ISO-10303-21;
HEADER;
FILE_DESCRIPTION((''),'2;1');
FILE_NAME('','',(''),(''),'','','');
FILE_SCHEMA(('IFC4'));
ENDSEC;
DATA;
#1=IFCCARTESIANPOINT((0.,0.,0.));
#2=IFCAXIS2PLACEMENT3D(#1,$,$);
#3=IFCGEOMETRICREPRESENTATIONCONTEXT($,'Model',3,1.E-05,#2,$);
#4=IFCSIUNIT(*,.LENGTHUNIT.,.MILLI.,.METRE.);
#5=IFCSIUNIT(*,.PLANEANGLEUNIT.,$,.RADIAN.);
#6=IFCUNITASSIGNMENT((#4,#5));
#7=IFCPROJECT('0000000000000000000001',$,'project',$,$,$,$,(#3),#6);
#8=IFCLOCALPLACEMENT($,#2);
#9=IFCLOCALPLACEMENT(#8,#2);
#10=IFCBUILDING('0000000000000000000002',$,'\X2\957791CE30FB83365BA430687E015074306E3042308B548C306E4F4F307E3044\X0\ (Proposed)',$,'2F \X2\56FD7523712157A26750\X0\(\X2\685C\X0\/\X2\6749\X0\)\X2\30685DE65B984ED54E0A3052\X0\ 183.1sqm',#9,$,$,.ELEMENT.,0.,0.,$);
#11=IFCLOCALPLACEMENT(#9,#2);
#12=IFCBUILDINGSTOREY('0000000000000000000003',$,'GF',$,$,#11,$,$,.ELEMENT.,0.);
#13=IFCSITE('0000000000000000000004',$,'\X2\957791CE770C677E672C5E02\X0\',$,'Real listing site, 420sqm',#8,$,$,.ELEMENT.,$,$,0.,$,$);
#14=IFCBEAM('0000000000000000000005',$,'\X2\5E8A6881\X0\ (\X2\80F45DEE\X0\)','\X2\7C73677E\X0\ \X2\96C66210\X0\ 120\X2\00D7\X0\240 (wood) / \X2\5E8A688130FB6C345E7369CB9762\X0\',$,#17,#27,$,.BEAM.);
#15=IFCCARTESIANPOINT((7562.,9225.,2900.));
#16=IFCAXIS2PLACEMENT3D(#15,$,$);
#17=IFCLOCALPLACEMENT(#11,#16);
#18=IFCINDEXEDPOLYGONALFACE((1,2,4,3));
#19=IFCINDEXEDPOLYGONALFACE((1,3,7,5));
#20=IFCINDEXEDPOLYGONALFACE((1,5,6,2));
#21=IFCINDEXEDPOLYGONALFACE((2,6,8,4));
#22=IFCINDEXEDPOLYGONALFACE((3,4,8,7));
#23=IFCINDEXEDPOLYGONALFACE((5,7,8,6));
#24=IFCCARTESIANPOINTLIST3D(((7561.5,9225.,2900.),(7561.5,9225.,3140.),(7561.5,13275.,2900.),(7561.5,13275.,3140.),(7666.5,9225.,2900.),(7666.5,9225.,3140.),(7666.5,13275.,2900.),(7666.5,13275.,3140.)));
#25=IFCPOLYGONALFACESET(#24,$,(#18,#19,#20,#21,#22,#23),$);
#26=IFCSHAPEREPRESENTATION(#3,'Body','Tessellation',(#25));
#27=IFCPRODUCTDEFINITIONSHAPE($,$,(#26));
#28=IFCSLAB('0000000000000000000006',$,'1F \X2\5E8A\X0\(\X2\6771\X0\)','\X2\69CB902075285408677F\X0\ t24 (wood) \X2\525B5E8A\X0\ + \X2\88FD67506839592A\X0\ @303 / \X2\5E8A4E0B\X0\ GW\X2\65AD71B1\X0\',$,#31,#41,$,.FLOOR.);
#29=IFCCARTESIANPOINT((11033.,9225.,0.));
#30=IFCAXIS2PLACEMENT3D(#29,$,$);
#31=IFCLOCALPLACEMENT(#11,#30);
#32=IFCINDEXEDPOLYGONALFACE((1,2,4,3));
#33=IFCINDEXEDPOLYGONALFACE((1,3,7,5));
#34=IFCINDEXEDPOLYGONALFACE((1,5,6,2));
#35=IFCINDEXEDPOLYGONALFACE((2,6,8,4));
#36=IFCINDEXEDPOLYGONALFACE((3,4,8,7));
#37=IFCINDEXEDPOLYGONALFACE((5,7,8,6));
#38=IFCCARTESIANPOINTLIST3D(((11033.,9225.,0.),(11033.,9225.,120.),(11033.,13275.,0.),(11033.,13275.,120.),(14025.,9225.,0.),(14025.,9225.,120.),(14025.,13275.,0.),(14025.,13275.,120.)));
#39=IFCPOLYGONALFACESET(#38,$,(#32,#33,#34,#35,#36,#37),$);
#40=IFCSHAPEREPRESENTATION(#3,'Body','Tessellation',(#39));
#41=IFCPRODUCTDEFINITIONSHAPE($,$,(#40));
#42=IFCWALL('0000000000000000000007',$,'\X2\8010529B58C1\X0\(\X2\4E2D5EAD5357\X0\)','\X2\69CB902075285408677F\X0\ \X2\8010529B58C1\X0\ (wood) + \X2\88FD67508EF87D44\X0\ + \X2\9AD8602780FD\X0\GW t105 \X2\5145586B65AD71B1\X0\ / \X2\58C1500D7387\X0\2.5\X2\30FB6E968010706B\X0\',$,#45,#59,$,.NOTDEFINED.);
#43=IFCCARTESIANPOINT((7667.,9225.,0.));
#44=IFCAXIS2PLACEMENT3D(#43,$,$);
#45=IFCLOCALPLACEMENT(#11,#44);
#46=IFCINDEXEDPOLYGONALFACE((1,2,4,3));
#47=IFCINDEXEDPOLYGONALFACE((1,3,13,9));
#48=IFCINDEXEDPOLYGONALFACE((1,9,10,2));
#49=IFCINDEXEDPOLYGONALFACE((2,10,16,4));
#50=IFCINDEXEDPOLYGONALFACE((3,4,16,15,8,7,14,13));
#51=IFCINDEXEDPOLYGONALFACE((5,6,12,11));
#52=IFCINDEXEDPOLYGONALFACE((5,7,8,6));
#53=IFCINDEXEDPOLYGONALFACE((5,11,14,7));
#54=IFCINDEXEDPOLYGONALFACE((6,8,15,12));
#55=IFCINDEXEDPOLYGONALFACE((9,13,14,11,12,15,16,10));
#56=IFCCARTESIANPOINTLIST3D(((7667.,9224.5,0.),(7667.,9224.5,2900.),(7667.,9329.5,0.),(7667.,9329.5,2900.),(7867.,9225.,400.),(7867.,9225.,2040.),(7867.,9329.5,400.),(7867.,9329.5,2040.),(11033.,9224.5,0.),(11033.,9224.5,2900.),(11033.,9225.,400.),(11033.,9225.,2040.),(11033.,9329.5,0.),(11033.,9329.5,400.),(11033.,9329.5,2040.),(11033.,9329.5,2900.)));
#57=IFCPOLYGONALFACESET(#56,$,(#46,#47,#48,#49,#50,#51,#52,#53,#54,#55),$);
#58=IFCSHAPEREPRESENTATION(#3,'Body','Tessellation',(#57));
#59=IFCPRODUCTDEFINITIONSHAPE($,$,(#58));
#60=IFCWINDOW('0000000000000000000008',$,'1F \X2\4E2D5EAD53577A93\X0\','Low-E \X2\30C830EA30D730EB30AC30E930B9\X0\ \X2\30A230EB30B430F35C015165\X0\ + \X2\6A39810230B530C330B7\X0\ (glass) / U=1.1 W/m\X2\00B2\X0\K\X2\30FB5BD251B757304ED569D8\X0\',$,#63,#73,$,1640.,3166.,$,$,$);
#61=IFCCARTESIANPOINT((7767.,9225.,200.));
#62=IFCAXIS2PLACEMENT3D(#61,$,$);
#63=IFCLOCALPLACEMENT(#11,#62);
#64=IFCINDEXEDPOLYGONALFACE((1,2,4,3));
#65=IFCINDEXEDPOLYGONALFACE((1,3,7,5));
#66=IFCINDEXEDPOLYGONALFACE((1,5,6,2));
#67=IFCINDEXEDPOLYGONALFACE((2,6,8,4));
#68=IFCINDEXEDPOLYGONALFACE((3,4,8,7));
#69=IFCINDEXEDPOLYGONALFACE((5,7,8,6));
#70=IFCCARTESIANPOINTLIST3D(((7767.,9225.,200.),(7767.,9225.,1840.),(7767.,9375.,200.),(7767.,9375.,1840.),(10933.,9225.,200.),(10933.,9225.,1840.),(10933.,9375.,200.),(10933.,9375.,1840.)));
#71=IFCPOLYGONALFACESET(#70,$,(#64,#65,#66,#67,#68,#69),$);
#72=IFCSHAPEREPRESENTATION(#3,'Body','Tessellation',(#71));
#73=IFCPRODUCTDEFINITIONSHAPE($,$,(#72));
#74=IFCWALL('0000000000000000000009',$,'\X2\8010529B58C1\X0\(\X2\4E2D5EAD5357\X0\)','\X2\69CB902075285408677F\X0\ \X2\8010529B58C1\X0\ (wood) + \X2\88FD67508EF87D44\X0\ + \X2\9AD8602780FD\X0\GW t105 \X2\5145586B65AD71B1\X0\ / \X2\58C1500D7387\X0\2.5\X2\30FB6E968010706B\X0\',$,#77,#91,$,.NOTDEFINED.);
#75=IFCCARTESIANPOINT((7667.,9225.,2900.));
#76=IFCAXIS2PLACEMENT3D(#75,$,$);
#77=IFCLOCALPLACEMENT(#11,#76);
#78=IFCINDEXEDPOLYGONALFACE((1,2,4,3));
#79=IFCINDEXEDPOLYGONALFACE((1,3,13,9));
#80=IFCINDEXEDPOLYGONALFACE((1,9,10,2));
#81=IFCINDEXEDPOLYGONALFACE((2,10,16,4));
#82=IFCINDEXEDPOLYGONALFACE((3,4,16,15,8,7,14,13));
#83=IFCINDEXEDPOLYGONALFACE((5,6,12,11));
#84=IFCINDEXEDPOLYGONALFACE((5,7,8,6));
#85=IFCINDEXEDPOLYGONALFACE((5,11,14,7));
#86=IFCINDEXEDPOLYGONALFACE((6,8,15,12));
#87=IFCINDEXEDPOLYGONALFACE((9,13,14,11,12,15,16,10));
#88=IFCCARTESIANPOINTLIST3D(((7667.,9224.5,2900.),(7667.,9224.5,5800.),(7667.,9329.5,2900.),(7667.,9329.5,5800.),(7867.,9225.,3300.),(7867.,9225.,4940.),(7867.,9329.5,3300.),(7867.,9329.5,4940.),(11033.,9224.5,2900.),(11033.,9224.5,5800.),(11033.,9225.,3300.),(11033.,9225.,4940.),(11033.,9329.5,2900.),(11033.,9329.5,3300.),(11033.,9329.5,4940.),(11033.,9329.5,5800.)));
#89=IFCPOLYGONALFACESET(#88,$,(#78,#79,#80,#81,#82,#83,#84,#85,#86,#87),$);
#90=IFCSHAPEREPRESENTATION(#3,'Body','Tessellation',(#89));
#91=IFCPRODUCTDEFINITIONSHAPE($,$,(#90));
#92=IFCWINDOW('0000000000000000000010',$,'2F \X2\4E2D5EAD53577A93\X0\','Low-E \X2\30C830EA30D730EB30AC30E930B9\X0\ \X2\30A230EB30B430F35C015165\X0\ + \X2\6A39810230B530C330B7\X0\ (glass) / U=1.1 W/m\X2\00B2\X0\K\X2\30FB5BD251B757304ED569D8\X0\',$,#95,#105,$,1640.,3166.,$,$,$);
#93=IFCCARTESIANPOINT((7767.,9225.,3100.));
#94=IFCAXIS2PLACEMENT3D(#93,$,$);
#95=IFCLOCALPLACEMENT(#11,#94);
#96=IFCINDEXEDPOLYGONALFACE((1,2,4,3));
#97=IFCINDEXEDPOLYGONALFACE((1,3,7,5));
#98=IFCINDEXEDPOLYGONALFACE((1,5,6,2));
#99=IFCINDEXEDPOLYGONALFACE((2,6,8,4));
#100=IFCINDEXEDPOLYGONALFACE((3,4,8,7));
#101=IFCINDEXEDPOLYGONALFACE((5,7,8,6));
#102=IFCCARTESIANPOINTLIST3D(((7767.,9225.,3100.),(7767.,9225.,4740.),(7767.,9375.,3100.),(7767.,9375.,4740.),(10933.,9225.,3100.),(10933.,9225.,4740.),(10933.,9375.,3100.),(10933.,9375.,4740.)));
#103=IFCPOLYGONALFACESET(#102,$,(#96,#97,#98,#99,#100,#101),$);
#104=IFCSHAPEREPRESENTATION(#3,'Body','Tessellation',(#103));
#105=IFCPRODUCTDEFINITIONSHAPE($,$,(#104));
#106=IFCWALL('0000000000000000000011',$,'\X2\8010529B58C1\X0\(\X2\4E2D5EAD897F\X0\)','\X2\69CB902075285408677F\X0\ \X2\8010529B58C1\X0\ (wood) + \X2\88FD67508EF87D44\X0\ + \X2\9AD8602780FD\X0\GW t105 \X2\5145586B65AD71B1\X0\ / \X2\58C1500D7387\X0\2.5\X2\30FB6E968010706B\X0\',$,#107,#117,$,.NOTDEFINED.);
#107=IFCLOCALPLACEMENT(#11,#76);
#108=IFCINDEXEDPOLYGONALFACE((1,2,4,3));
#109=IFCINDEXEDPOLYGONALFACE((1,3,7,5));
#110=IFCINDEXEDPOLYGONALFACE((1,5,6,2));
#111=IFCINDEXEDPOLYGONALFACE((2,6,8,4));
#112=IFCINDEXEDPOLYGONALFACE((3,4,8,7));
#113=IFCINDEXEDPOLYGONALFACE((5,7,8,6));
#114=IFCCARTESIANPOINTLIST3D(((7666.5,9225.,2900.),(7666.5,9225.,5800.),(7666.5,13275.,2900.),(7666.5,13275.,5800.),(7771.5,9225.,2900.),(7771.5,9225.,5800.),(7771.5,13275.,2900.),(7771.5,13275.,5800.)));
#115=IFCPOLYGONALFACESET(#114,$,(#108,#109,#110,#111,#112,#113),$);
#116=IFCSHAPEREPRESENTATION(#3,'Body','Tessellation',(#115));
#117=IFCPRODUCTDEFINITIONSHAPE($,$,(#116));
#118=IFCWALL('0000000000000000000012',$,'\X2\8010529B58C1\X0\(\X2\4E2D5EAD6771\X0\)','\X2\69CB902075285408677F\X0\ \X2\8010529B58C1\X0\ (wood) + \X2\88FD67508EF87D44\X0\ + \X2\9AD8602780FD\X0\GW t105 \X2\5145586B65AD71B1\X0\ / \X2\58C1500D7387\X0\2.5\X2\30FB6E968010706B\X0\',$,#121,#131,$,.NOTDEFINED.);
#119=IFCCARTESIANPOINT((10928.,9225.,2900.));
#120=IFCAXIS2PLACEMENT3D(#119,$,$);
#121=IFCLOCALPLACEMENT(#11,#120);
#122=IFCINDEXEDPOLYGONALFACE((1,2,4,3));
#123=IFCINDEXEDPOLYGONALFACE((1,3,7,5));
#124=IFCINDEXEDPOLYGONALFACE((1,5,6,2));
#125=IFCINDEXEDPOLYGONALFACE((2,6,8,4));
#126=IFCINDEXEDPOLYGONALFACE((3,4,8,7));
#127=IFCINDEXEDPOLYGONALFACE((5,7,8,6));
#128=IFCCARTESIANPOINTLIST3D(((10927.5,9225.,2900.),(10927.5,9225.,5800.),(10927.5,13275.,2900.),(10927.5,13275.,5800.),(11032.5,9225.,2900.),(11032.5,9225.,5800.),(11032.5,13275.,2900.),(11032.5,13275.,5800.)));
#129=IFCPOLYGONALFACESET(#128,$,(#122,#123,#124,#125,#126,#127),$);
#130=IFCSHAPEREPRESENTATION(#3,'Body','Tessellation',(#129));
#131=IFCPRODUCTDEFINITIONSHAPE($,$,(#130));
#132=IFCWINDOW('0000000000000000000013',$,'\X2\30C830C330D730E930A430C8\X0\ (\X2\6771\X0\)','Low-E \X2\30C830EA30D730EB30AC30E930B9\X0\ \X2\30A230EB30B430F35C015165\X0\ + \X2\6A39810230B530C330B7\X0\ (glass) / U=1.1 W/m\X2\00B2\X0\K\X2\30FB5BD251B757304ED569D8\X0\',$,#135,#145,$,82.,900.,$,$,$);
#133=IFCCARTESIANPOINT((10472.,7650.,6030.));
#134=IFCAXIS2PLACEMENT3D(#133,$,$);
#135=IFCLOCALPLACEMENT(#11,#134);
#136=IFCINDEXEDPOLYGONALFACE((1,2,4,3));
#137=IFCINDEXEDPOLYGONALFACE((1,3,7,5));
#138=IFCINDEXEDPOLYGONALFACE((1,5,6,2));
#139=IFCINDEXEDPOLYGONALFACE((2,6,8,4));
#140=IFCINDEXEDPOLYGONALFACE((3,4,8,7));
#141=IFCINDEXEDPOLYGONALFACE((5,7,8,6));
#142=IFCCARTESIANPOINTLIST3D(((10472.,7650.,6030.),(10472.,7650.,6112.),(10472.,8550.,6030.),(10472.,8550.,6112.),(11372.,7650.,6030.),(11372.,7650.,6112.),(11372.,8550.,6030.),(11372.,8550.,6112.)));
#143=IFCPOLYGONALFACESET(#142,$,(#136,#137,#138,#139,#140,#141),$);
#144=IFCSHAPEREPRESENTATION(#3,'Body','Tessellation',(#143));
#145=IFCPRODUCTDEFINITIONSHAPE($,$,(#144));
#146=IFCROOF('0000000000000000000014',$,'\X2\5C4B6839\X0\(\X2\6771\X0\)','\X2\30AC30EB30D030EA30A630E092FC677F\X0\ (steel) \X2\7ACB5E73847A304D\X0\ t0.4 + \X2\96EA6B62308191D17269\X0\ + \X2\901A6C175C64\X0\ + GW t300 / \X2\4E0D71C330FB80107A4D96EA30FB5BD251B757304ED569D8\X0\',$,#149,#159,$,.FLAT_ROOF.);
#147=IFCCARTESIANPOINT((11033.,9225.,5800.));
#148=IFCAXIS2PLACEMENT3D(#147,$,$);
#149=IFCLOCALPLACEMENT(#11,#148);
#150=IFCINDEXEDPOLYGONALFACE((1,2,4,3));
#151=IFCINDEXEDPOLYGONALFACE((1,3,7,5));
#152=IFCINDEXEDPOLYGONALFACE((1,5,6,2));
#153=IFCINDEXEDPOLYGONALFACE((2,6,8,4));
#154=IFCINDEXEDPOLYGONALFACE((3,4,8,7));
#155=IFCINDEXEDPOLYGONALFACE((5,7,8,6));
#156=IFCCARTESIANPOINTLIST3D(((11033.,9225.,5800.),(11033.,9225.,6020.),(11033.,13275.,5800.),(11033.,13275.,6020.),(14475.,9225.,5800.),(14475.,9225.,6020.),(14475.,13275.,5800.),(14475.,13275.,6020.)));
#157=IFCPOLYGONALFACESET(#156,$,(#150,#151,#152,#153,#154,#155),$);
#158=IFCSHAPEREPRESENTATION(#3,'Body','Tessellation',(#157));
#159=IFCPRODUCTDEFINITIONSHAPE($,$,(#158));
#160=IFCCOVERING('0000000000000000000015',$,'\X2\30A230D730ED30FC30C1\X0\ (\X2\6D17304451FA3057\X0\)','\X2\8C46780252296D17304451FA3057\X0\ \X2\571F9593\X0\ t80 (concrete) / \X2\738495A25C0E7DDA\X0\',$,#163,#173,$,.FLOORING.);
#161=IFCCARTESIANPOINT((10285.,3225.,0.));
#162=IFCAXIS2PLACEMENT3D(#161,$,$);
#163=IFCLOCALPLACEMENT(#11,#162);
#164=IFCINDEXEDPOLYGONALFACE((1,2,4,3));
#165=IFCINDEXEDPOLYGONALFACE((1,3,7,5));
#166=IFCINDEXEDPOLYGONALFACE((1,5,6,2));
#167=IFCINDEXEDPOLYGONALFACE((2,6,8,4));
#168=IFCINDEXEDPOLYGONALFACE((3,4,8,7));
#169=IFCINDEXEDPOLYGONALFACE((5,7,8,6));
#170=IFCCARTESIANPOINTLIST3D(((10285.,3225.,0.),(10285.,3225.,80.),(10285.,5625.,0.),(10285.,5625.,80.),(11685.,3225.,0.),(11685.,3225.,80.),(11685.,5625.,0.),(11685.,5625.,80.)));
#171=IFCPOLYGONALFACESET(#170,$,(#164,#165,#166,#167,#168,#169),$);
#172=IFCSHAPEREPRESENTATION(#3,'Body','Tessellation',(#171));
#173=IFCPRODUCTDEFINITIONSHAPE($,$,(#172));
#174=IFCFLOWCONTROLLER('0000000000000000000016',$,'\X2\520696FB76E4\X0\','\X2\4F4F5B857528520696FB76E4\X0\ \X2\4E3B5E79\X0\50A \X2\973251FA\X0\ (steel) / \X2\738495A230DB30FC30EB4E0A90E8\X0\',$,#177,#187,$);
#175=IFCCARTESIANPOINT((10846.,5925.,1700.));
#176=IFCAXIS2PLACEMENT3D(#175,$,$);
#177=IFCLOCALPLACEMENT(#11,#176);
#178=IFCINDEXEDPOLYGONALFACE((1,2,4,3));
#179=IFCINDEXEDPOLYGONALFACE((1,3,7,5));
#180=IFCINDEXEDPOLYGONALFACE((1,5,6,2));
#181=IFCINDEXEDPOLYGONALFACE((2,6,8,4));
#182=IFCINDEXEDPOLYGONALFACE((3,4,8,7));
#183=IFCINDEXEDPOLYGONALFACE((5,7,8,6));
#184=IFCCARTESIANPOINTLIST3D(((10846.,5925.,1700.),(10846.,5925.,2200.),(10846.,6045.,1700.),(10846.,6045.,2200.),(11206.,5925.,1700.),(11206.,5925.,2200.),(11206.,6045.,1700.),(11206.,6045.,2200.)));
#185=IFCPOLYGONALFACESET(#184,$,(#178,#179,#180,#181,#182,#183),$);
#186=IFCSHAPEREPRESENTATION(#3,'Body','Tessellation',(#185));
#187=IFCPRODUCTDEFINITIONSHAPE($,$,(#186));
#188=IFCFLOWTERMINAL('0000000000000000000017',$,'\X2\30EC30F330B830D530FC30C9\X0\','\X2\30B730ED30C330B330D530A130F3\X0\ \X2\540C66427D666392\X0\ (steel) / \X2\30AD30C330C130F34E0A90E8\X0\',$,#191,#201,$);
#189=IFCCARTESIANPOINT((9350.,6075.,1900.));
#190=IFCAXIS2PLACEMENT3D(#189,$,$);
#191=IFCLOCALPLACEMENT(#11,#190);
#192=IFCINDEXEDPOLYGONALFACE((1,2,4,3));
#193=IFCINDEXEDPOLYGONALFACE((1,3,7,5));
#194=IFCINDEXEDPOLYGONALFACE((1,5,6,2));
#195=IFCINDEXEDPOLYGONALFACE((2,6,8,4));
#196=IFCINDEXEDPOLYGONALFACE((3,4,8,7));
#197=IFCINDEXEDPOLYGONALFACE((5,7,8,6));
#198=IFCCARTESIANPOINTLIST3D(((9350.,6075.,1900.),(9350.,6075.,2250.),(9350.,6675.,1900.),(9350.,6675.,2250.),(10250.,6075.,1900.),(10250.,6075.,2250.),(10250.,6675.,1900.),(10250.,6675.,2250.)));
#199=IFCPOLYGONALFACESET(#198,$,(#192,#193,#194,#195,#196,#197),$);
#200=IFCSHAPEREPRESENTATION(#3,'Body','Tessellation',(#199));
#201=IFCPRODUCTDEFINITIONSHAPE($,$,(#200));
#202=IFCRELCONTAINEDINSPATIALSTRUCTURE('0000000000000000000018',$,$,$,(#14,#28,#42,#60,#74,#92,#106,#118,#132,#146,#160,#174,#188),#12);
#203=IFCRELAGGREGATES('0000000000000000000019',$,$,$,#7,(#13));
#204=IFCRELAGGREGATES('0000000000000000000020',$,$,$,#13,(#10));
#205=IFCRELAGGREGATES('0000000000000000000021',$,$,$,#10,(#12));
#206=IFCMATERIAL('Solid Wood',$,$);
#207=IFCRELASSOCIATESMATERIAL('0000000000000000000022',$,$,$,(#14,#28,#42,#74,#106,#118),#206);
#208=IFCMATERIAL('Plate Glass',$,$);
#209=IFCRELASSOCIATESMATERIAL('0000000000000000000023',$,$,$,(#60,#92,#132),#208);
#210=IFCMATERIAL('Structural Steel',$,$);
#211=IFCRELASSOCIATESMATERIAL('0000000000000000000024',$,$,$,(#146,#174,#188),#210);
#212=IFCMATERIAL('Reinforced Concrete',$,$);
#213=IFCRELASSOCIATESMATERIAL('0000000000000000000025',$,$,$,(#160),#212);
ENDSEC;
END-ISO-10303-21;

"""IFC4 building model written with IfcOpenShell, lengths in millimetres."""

from ifc_helpers import new_model, si_unit, frame, frame_2d, origin, place, context, project, spatial, rectangle, extrude, material, element, fill, save


model = new_model("IFC4")

# Units and contexts
model_context = context("Model", 3, precision=1e-05, world=origin())
ifc_project = project(units=[si_unit("LENGTHUNIT", "METRE", prefix="MILLI"), si_unit("PLANEANGLEUNIT", "RADIAN")], contexts=[model_context])

# Site, building, storey
site_placement = place(None, origin())
site = spatial("IfcSite", under=ifc_project, at=site_placement, Name="長野県松本市", ObjectType="Real listing site, 420sqm", CompositionType="ELEMENT", RefElevation=0.0)
building_placement = place(site_placement, origin())
building = spatial("IfcBuilding", under=site, at=building_placement, Name="長野・茶室と縁側のある和の住まい (Proposed)", ObjectType="2F 国産無垢材(桜/杉)と左官仕上げ 183.1sqm", CompositionType="ELEMENT", ElevationOfRefHeight=0.0, ElevationOfTerrain=0.0)
storey_placement = place(building_placement, origin())
storey = spatial("IfcBuildingStorey", under=building, at=storey_placement, Name="GF", CompositionType="ELEMENT", Elevation=0.0)

# Shared definitions
ifc_material_1 = material(Name="Solid Wood")

# Beam
beam_placement = place(storey_placement, frame((7562.0, 9225.0, 2900.0)))
element("IfcBeam", 1, at=beam_placement, inside=storey, material=ifc_material_1, Name="床梁 (胴差)", Description="米松 集成 120×240 (wood) / 床梁・水平構面", PredefinedType="BEAM", context=model_context, shape_type="SweptSolid", body=[
    extrude(rectangle(XDim=105.0, YDim=4050.0, at=frame_2d((52.0, 2025.0))), frame((7562.0, 9225.0, 2900.0)), (0.0, 0.0, 1.0), 240.0),
])

# Slab
slab_placement = place(storey_placement, frame((11033.0, 9225.0, 0.0)))
element("IfcSlab", 2, at=slab_placement, inside=storey, material=ifc_material_1, Name="1F 床(東)", Description="構造用合板 t24 (wood) 剛床 + 製材根太 @303 / 床下 GW断熱", PredefinedType="FLOOR", context=model_context, shape_type="SweptSolid", body=[
    extrude(rectangle(XDim=2992.0, YDim=4050.0, at=frame_2d((1496.0, 2025.0))), frame((11033.0, 9225.0, 0.0)), (0.0, 0.0, 1.0), 120.0),
])

# Wall, opening, window
wall_1_placement = place(storey_placement, frame((7667.0, 9225.0, 0.0)))
wall_1 = element("IfcWall", 3, at=wall_1_placement, inside=storey, material=ifc_material_1, Name="耐力壁(中庭南)", Description="構造用合板 耐力壁 (wood) + 製材軸組 + 高性能GW t105 充填断熱 / 壁倍率2.5・準耐火", PredefinedType="NOTDEFINED", context=model_context, shape_type="SweptSolid", body=[
    extrude(rectangle(XDim=3366.0, YDim=105.0, at=frame_2d((1683.0, 52.0))), frame((7667.0, 9225.0, 0.0)), (0.0, 0.0, 1.0), 2900.0),
])
opening_1_placement = place(storey_placement, frame((7767.0, 9225.0, 200.0)))
opening_1 = element("IfcOpeningElement", 4, at=opening_1_placement, cuts=wall_1, PredefinedType="NOTDEFINED", context=model_context, shape_type="SweptSolid", body=[
    extrude(rectangle(XDim=3166.0, YDim=150.0, at=frame_2d((1583.0, 75.0))), frame((7767.0, 9225.0, 200.0)), (0.0, 0.0, 1.0), 1640.0),
])
ifc_material_2 = material(Name="Plate Glass")
window_1_placement = place(storey_placement, frame((7767.0, 9225.0, 200.0)))
window_1 = element("IfcWindow", 5, at=window_1_placement, inside=storey, material=ifc_material_2, Name="1F 中庭南窓", Description="Low-E トリプルガラス アルゴン封入 + 樹脂サッシ (glass) / U=1.1 W/m²K・寒冷地仕様", OverallHeight=1640.0, OverallWidth=3166.0, context=model_context, shape_type="SweptSolid", body=[
    extrude(rectangle(XDim=3166.0, YDim=150.0, at=frame_2d((1583.0, 75.0))), frame((7767.0, 9225.0, 200.0)), (0.0, 0.0, 1.0), 1640.0),
])
fill(opening_1, window_1)

# Wall, opening, window
wall_2_placement = place(storey_placement, frame((7667.0, 9225.0, 2900.0)))
wall_2 = element("IfcWall", 6, at=wall_2_placement, inside=storey, material=ifc_material_1, Name="耐力壁(中庭南)", Description="構造用合板 耐力壁 (wood) + 製材軸組 + 高性能GW t105 充填断熱 / 壁倍率2.5・準耐火", PredefinedType="NOTDEFINED", context=model_context, shape_type="SweptSolid", body=[
    extrude(rectangle(XDim=3366.0, YDim=105.0, at=frame_2d((1683.0, 52.0))), frame((7667.0, 9225.0, 2900.0)), (0.0, 0.0, 1.0), 2900.0),
])
opening_2_placement = place(storey_placement, frame((7767.0, 9225.0, 3100.0)))
opening_2 = element("IfcOpeningElement", 7, at=opening_2_placement, cuts=wall_2, PredefinedType="NOTDEFINED", context=model_context, shape_type="SweptSolid", body=[
    extrude(rectangle(XDim=3166.0, YDim=150.0, at=frame_2d((1583.0, 75.0))), frame((7767.0, 9225.0, 3100.0)), (0.0, 0.0, 1.0), 1640.0),
])
window_2_placement = place(storey_placement, frame((7767.0, 9225.0, 3100.0)))
window_2 = element("IfcWindow", 8, at=window_2_placement, inside=storey, material=ifc_material_2, Name="2F 中庭南窓", Description="Low-E トリプルガラス アルゴン封入 + 樹脂サッシ (glass) / U=1.1 W/m²K・寒冷地仕様", OverallHeight=1640.0, OverallWidth=3166.0, context=model_context, shape_type="SweptSolid", body=[
    extrude(rectangle(XDim=3166.0, YDim=150.0, at=frame_2d((1583.0, 75.0))), frame((7767.0, 9225.0, 3100.0)), (0.0, 0.0, 1.0), 1640.0),
])
fill(opening_2, window_2)

# Walls
wall_3_placement = place(storey_placement, frame((7667.0, 9225.0, 2900.0)))
element("IfcWall", 9, at=wall_3_placement, inside=storey, material=ifc_material_1, Name="耐力壁(中庭西)", Description="構造用合板 耐力壁 (wood) + 製材軸組 + 高性能GW t105 充填断熱 / 壁倍率2.5・準耐火", PredefinedType="NOTDEFINED", context=model_context, shape_type="SweptSolid", body=[
    extrude(rectangle(XDim=105.0, YDim=4050.0, at=frame_2d((52.0, 2025.0))), frame((7667.0, 9225.0, 2900.0)), (0.0, 0.0, 1.0), 2900.0),
])
wall_4_placement = place(storey_placement, frame((10928.0, 9225.0, 2900.0)))
element("IfcWall", 10, at=wall_4_placement, inside=storey, material=ifc_material_1, Name="耐力壁(中庭東)", Description="構造用合板 耐力壁 (wood) + 製材軸組 + 高性能GW t105 充填断熱 / 壁倍率2.5・準耐火", PredefinedType="NOTDEFINED", context=model_context, shape_type="SweptSolid", body=[
    extrude(rectangle(XDim=105.0, YDim=4050.0, at=frame_2d((52.0, 2025.0))), frame((10928.0, 9225.0, 2900.0)), (0.0, 0.0, 1.0), 2900.0),
])

# Window
window_3_placement = place(storey_placement, frame((10472.0, 7650.0, 6030.0)))
element("IfcWindow", 11, at=window_3_placement, inside=storey, material=ifc_material_2, Name="トップライト (東)", Description="Low-E トリプルガラス アルゴン封入 + 樹脂サッシ (glass) / U=1.1 W/m²K・寒冷地仕様", OverallHeight=82.0, OverallWidth=900.0, context=model_context, shape_type="SweptSolid", body=[
    extrude(rectangle(XDim=900.0, YDim=900.0, at=frame_2d((450.0, 450.0))), frame((10472.0, 7650.0, 6030.0)), (0.0, 0.0, 1.0), 82.0),
])

# Roof
ifc_material_3 = material(Name="Structural Steel")
roof_placement = place(storey_placement, frame((11033.0, 9225.0, 5800.0)))
element("IfcRoof", 12, at=roof_placement, inside=storey, material=ifc_material_3, Name="屋根(東)", Description="ガルバリウム鋼板 (steel) 立平葺き t0.4 + 雪止め金物 + 通気層 + GW t300 / 不燃・耐積雪・寒冷地仕様", PredefinedType="FLAT_ROOF", context=model_context, shape_type="SweptSolid", body=[
    extrude(rectangle(XDim=3442.0, YDim=4050.0, at=frame_2d((1721.0, 2025.0))), frame((11033.0, 9225.0, 5800.0)), (0.0, 0.0, 1.0), 220.0),
])

# Covering
ifc_material_4 = material(Name="Reinforced Concrete")
covering_placement = place(storey_placement, frame((10285.0, 3225.0, 0.0)))
element("IfcCovering", 13, at=covering_placement, inside=storey, material=ifc_material_4, Name="アプローチ (洗い出し)", Description="豆砂利洗い出し 土間 t80 (concrete) / 玄関導線", PredefinedType="FLOORING", context=model_context, shape_type="SweptSolid", body=[
    extrude(rectangle(XDim=1400.0, YDim=2400.0, at=frame_2d((700.0, 1200.0))), frame((10285.0, 3225.0, 0.0)), (0.0, 0.0, 1.0), 80.0),
])

# Flow controller
flow_controller_placement = place(storey_placement, frame((10846.0, 5925.0, 1700.0)))
element("IfcFlowController", 14, at=flow_controller_placement, inside=storey, material=ifc_material_3, Name="分電盤", Description="住宅用分電盤 主幹50A 露出 (steel) / 玄関ホール上部", context=model_context, shape_type="SweptSolid", body=[
    extrude(rectangle(XDim=360.0, YDim=120.0, at=frame_2d((180.0, 60.0))), frame((10846.0, 5925.0, 1700.0)), (0.0, 0.0, 1.0), 500.0),
])

# Flow terminal
flow_terminal_1_placement = place(storey_placement, frame((9350.0, 6075.0, 1900.0)))
element("IfcFlowTerminal", 15, at=flow_terminal_1_placement, inside=storey, material=ifc_material_3, Name="レンジフード", Description="シロッコファン 同時給排 (steel) / キッチン上部", context=model_context, shape_type="SweptSolid", body=[
    extrude(rectangle(XDim=900.0, YDim=600.0, at=frame_2d((450.0, 300.0))), frame((9350.0, 6075.0, 1900.0)), (0.0, 0.0, 1.0), 350.0),
])

save(model, "model.ifc")
